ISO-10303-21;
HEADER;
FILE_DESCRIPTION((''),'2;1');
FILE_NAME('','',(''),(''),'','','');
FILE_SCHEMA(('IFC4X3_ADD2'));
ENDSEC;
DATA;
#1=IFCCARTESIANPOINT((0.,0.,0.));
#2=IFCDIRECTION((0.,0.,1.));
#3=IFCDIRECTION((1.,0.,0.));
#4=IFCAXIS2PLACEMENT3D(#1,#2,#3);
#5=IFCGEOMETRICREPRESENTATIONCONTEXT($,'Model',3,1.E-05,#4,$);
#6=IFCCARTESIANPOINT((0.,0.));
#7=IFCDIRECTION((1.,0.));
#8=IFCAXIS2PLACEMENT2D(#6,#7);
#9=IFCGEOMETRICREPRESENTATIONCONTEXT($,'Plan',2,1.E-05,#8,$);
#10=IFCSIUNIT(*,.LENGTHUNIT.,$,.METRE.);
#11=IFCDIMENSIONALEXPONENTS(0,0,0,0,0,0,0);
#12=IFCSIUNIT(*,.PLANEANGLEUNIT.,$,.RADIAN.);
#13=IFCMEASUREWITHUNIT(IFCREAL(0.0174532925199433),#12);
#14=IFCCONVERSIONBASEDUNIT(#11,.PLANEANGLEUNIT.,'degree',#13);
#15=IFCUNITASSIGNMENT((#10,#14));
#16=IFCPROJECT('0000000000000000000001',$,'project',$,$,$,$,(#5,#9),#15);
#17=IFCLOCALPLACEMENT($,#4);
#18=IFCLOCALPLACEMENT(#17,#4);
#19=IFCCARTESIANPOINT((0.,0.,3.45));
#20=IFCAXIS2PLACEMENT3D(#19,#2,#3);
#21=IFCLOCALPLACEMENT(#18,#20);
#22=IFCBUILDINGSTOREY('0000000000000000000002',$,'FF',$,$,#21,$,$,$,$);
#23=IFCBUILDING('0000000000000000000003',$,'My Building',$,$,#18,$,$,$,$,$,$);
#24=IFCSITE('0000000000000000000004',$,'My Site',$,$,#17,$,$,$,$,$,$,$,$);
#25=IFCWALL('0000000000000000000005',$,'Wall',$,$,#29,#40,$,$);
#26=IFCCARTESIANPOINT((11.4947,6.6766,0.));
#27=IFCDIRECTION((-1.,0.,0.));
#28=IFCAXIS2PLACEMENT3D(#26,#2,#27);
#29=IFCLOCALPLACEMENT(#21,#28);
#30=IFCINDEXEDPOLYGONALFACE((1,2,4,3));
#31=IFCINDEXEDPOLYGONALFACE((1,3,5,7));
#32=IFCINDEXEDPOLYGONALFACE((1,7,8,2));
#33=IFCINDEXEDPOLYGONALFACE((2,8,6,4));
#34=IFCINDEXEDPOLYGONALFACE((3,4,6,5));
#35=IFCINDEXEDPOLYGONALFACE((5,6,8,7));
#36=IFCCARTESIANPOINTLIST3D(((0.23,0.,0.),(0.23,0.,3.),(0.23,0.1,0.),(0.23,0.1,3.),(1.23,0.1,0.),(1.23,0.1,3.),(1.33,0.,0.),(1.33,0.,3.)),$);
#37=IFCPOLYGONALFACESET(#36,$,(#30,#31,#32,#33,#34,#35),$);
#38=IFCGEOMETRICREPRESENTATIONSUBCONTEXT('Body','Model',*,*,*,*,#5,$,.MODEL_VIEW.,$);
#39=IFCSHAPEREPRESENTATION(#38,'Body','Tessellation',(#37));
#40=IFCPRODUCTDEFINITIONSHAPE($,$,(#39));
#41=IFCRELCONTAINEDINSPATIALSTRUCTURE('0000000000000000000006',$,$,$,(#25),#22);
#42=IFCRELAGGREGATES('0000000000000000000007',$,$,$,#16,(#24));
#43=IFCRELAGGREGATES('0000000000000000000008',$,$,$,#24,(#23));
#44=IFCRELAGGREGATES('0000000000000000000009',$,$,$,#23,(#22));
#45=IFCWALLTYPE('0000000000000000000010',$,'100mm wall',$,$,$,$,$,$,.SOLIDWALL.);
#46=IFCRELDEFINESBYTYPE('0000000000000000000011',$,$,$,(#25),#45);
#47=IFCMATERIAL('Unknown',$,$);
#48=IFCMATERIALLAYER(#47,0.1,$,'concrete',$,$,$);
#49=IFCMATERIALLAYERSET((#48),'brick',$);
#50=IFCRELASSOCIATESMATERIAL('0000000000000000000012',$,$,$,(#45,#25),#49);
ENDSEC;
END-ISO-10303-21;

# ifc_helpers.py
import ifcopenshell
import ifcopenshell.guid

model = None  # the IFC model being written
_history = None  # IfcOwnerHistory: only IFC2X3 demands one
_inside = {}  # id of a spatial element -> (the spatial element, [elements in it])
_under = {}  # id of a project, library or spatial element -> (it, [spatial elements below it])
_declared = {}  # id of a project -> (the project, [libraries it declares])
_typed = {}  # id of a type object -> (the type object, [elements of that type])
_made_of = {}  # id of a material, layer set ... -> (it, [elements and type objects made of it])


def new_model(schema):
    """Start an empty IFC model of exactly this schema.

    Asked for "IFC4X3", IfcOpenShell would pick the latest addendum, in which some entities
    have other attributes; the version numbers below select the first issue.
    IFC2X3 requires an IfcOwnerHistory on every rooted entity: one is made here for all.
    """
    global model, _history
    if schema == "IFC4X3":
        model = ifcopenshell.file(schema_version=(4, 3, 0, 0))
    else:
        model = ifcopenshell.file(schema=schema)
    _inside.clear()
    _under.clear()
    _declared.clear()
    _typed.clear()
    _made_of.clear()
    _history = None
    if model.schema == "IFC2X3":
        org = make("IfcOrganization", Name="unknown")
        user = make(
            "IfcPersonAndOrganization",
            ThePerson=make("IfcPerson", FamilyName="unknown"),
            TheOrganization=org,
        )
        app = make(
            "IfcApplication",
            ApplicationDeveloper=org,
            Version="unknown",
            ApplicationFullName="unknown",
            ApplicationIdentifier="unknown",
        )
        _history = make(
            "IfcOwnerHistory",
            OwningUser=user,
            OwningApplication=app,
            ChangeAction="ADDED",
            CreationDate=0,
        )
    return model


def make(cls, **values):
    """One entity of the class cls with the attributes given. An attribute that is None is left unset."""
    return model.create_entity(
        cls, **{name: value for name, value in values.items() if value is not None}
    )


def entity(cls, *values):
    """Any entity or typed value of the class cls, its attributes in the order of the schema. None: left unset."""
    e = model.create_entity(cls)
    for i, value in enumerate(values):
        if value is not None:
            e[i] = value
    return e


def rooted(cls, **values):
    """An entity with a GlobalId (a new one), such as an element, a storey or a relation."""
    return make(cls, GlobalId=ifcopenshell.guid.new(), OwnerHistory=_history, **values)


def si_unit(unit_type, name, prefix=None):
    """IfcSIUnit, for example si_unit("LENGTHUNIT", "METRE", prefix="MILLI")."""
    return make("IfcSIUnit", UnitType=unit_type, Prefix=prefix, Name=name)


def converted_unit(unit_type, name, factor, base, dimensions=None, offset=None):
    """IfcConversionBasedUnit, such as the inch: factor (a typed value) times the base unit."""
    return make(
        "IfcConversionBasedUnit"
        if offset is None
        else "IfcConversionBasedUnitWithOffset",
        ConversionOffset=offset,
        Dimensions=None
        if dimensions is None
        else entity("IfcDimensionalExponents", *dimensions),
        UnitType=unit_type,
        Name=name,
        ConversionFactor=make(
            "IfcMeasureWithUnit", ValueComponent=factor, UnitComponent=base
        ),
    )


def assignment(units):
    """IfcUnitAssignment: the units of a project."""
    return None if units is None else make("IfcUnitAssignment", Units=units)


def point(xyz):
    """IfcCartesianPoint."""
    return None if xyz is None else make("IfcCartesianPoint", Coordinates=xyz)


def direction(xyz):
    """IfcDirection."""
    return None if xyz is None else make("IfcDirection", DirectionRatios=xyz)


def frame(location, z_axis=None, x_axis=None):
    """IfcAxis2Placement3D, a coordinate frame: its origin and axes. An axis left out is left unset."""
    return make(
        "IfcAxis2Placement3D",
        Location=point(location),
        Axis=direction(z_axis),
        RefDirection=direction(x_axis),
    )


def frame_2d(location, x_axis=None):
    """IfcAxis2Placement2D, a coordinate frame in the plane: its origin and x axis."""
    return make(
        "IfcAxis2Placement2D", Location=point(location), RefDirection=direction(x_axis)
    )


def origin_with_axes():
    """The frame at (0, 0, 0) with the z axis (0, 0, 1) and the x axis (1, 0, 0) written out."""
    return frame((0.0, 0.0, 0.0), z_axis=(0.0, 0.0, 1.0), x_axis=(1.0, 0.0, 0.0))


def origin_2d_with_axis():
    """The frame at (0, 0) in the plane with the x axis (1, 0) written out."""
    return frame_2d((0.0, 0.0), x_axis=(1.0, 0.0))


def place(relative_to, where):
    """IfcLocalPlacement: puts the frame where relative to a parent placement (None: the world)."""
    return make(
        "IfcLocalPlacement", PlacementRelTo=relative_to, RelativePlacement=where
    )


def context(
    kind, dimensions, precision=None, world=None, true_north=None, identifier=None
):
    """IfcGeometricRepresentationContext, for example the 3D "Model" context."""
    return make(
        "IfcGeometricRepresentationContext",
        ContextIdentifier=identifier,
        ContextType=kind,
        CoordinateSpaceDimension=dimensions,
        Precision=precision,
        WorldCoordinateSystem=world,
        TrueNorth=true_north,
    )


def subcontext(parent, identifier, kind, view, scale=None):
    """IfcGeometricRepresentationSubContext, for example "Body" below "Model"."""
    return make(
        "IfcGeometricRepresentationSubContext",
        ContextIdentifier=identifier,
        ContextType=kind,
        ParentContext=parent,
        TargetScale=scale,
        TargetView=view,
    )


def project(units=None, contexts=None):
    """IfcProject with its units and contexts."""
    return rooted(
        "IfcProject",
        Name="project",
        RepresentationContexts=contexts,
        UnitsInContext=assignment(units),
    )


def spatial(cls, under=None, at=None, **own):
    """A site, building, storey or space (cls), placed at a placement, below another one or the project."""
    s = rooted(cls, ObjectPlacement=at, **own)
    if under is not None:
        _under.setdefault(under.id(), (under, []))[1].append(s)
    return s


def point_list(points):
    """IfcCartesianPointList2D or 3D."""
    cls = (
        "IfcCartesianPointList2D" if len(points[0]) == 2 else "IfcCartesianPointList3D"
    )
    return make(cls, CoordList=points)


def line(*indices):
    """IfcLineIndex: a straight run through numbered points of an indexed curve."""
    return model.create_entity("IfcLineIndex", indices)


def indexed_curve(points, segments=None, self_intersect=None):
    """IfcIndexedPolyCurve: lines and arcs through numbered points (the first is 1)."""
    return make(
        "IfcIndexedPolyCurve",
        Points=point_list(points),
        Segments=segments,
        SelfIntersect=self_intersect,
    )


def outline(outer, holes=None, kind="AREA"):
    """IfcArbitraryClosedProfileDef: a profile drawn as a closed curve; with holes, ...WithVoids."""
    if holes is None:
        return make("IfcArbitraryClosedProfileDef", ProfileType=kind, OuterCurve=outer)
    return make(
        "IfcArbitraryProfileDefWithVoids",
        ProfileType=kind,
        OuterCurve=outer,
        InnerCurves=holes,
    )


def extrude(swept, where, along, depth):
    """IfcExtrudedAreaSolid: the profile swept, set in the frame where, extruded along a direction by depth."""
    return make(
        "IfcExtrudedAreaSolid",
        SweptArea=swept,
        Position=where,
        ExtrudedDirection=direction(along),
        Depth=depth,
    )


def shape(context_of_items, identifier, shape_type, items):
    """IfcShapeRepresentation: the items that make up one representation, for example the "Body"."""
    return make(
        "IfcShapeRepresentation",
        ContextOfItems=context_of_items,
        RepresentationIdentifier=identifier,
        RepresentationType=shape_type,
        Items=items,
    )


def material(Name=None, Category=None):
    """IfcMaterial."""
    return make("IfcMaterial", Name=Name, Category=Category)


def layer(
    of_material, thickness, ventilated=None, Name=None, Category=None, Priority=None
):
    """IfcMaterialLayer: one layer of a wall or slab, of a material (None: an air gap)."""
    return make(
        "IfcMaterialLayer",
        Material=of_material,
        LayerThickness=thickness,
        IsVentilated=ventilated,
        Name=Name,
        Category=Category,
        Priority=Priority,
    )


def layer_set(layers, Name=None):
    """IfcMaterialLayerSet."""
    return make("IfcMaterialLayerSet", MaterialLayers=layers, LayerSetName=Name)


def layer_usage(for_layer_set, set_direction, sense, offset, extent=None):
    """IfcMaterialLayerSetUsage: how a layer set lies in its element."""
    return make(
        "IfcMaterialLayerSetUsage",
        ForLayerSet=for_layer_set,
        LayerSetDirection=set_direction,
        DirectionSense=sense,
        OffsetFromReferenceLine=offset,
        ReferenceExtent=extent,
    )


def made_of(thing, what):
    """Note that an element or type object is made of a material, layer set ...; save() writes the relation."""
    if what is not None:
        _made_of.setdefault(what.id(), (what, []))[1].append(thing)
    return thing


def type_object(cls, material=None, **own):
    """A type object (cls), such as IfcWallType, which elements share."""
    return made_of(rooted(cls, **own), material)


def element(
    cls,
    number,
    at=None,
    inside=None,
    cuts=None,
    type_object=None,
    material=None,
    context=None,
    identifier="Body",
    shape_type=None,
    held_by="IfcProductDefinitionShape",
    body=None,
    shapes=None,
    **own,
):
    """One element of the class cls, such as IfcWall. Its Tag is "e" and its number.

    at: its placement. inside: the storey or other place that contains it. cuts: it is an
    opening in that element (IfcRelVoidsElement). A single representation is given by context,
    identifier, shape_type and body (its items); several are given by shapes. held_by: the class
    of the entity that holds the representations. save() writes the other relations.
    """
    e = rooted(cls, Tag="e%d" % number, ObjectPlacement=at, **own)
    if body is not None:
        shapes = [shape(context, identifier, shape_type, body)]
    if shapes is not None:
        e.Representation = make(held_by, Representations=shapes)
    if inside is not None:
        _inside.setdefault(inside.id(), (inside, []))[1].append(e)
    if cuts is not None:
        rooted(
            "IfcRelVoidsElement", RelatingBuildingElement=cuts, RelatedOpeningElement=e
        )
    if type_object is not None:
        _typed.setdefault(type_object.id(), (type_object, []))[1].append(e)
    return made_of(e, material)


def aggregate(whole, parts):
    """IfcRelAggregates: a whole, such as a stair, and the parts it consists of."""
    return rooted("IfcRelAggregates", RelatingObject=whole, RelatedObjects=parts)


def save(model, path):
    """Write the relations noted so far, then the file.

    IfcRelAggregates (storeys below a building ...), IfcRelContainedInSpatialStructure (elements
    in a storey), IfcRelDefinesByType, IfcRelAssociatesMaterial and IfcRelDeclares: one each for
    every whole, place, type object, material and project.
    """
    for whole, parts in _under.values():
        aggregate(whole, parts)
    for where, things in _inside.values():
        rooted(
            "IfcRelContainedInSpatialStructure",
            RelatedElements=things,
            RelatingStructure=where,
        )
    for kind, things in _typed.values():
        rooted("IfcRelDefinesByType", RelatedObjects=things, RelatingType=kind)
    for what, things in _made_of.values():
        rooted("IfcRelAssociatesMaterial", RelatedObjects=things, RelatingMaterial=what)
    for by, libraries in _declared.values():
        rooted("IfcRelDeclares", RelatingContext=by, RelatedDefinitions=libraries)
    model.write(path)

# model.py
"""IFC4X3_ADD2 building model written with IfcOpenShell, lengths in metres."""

from ifc_helpers import new_model, entity, si_unit, converted_unit, frame, origin_with_axes, origin_2d_with_axis, place, context, subcontext, project, spatial, line, indexed_curve, outline, extrude, material, layer, layer_set, layer_usage, type_object, element, save


model = new_model("IFC4X3_ADD2")

# Units and contexts
model_context = context("Model", 3, precision=1e-05, world=origin_with_axes())
plan_context = context("Plan", 2, precision=1e-05, world=origin_2d_with_axis())
body_context_1 = subcontext(model_context, "Body", "Model", "MODEL_VIEW")
ifc_project = project(units=[si_unit("LENGTHUNIT", "METRE"), converted_unit("PLANEANGLEUNIT", "degree", entity("IfcReal", 0.0174532925199433), si_unit("PLANEANGLEUNIT", "RADIAN"), dimensions=[0, 0, 0, 0, 0, 0, 0])], contexts=[model_context, plan_context])

# Site, building, storey
site_placement = place(None, origin_with_axes())
site = spatial("IfcSite", under=ifc_project, at=site_placement, Name="My Site")
building_placement = place(site_placement, origin_with_axes())
building = spatial("IfcBuilding", under=site, at=building_placement, Name="My Building")
storey_placement = place(building_placement, frame((0.0, 0.0, 3.45), z_axis=(0.0, 0.0, 1.0), x_axis=(1.0, 0.0, 0.0)))
storey = spatial("IfcBuildingStorey", under=building, at=storey_placement, Name="FF")

# Shared definitions
ifc_material = material(Name="Unknown")

# Shared definitions
ifc_layer_1 = layer(ifc_material, 0.1, Name="concrete")
ifc_layer_set_1 = layer_set([ifc_layer_1], Name="brick")
wall_type_1 = type_object("IfcWallType", Name="100mm wall", PredefinedType="SOLIDWALL", material=ifc_layer_set_1)

# Wall
ifc_layer_usage_1 = layer_usage(ifc_layer_set_1, "AXIS2", "POSITIVE", 0.0)
wall_1_placement = place(storey_placement, frame((11.4947, 6.6766, 0.0), z_axis=(0.0, 0.0, 1.0), x_axis=(-1.0, 0.0, 0.0)))
element("IfcWall", 1, at=wall_1_placement, inside=storey, type_object=wall_type_1, material=ifc_layer_usage_1, Name="Wall", context=body_context_1, shape_type="SweptSolid", body=[
    extrude(outline(indexed_curve([(0.23, 0.0), (0.23, 0.1), (1.23, 0.1), (1.33, 0.0)], segments=[line(1, 2, 3, 4, 1)])), origin_with_axes(), (0.0, 0.0, 1.0), 3.0),
])

save(model, "model.ifc")
